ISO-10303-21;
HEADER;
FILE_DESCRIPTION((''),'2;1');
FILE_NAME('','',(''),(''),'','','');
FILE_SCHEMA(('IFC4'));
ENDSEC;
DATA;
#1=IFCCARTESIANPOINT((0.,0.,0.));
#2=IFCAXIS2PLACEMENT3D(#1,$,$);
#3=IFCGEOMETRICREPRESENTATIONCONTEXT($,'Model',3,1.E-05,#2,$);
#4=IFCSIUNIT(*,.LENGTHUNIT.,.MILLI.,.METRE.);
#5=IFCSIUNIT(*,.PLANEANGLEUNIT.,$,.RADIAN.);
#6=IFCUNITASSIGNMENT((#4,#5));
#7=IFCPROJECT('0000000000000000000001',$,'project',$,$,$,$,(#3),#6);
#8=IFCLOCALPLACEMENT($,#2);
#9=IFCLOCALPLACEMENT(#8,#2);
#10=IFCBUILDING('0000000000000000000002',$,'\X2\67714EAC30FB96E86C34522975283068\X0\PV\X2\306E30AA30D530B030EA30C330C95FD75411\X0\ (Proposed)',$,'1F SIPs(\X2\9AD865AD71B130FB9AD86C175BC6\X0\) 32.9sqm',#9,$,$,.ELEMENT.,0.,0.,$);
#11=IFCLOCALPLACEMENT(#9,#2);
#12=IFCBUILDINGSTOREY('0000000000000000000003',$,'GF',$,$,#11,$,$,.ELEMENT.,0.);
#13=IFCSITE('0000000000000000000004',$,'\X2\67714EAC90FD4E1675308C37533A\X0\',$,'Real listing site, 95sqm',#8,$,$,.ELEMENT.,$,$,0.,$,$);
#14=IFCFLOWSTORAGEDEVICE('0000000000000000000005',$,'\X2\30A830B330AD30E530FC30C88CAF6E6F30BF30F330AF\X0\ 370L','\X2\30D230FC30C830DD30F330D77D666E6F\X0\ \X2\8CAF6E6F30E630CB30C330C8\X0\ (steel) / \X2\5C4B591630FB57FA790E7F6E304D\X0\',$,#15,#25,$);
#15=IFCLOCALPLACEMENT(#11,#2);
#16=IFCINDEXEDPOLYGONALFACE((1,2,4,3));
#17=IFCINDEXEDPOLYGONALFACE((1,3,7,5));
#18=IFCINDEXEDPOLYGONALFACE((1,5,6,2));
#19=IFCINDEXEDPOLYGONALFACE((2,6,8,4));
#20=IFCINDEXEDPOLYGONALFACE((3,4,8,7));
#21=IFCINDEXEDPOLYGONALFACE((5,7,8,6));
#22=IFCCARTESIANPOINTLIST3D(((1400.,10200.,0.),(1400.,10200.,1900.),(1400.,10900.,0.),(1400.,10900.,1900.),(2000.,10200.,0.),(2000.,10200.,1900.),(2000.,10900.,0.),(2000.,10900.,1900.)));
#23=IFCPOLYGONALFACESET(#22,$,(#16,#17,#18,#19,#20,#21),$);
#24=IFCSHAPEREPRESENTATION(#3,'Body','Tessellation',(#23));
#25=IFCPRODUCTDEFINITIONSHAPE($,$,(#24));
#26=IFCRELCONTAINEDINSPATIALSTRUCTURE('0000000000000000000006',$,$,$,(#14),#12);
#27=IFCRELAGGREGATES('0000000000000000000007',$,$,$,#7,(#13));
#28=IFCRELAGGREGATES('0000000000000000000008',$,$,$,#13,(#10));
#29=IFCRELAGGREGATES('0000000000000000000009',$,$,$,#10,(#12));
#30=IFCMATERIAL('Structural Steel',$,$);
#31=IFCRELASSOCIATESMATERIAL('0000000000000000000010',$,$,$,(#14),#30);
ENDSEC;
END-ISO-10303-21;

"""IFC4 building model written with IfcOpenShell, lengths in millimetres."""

from ifc_helpers import new_model, si_unit, frame, frame_2d, origin, place, context, project, spatial, rectangle, extrude, material, element, save


model = new_model("IFC4")

# Units and contexts
model_context = context("Model", 3, precision=1e-05, world=origin())
ifc_project = project(units=[si_unit("LENGTHUNIT", "METRE", prefix="MILLI"), si_unit("PLANEANGLEUNIT", "RADIAN")], contexts=[model_context])

# Site, building, storey
site_placement = place(None, origin())
site = spatial("IfcSite", under=ifc_project, at=site_placement, Name="東京都世田谷区", ObjectType="Real listing site, 95sqm", CompositionType="ELEMENT", RefElevation=0.0)
building_placement = place(site_placement, origin())
building = spatial("IfcBuilding", under=site, at=building_placement, Name="東京・雨水利用とPVのオフグリッド志向 (Proposed)", ObjectType="1F SIPs(高断熱・高気密) 32.9sqm", CompositionType="ELEMENT", ElevationOfRefHeight=0.0, ElevationOfTerrain=0.0)
storey_placement = place(building_placement, origin())
storey = spatial("IfcBuildingStorey", under=building, at=storey_placement, Name="GF", CompositionType="ELEMENT", Elevation=0.0)

# Shared definitions
ifc_material_1 = material(Name="Structural Steel")

# Flow storage device
flow_storage_device_placement = place(storey_placement, frame((700.0, 5100.0, 0.0)))
element("IfcFlowStorageDevice", 1, at=flow_storage_device_placement, inside=storey, material=ifc_material_1, Name="エコキュート貯湯タンク 370L", Description="ヒートポンプ給湯 貯湯ユニット (steel) / 屋外・基礎置き", context=model_context, shape_type="SweptSolid", body=[
    extrude(rectangle(XDim=600.0, YDim=700.0, at=frame_2d((300.0, 350.0))), frame((700.0, 5100.0, 0.0)), (0.0, 0.0, 1.0), 1900.0),
])

save(model, "model.ifc")
